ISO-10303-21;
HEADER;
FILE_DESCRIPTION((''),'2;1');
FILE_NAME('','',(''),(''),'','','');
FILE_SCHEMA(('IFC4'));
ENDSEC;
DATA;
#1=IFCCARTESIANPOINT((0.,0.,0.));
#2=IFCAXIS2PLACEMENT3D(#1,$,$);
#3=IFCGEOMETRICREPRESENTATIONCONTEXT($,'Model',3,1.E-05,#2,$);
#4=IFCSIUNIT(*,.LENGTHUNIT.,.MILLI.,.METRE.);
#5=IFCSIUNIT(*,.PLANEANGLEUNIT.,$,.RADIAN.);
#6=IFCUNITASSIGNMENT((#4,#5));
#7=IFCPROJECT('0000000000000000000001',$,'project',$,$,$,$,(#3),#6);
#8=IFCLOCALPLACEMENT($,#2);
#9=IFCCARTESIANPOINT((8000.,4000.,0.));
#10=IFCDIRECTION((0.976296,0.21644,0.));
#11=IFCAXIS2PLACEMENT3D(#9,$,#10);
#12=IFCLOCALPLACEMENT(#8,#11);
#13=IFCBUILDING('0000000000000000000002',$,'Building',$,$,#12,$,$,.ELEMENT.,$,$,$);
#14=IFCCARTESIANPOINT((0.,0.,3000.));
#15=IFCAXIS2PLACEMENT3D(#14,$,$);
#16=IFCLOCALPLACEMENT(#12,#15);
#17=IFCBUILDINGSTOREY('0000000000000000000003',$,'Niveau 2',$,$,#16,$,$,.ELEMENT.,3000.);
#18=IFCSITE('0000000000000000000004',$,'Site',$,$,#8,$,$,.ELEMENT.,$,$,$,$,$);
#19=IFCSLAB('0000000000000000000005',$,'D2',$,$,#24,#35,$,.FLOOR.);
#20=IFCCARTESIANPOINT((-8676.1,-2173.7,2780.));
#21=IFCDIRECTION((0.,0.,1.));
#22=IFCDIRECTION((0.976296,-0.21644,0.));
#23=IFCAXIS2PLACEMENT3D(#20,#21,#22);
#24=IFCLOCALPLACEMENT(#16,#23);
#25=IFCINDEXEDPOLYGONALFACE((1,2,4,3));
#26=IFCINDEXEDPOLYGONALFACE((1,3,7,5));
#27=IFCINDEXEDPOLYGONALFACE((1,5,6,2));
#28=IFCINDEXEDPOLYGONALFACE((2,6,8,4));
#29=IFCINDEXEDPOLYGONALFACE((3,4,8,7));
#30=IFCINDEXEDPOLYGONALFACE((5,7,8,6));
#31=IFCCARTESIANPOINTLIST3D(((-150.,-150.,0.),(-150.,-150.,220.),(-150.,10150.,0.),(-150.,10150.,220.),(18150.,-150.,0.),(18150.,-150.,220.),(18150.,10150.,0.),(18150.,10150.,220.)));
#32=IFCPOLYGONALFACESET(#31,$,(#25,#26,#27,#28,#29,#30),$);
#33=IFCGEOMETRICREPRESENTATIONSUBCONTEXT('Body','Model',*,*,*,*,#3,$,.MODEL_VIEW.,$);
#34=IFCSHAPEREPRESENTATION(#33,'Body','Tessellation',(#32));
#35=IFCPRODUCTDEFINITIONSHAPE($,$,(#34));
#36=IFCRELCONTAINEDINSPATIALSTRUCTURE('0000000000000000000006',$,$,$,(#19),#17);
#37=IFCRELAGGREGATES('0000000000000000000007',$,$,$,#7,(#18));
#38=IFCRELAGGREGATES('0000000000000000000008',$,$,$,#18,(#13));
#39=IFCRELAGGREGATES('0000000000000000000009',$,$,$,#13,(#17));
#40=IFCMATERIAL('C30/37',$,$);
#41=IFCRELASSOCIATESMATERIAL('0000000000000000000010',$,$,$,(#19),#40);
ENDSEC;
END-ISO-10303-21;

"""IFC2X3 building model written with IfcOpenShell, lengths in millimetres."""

from ifc_helpers import new_model, si_unit, frame, origin, place, context, subcontext, project, spatial, polyline, outline, extrude, material, element, save


model = new_model("IFC2X3")

# Units and contexts
model_context = context("Model", 3, precision=1e-05, world=origin())
body_context = subcontext(model_context, "Body", "Model", "MODEL_VIEW")
ifc_project = project(units=[si_unit("LENGTHUNIT", "METRE", prefix="MILLI"), si_unit("PLANEANGLEUNIT", "RADIAN")], contexts=[model_context])

# Site, building, storey
site_placement = place(None, origin())
site = spatial("IfcSite", under=ifc_project, at=site_placement, Name="Site", CompositionType="ELEMENT")
building_placement = place(site_placement, frame((8000.0, 4000.0, 0.0), x_axis=(0.976296, 0.21644, 0.0)))
building = spatial("IfcBuilding", under=site, at=building_placement, Name="Building", CompositionType="ELEMENT")
storey_placement = place(building_placement, frame((0.0, 0.0, 3000.0)))
storey = spatial("IfcBuildingStorey", under=building, at=storey_placement, Name="Niveau 2", CompositionType="ELEMENT", Elevation=3000.0)

# Shared definitions
ifc_material = material(Name="C30/37")

# Slab
slab_placement = place(storey_placement, frame((-8676.1, -2173.7, 2780.0), z_axis=(0.0, 0.0, 1.0), x_axis=(0.976296, -0.21644, 0.0)))
element("IfcSlab", 1, at=slab_placement, inside=storey, material=ifc_material, Name="D2", PredefinedType="FLOOR", context=body_context, shape_type="SweptSolid", body=[
    extrude(outline(polyline([(-150.0, -150.0), (18150.0, -150.0), (18150.0, 10150.0), (-150.0, 10150.0), (-150.0, -150.0)])), origin(), (0.0, 0.0, 1.0), 220.0),
])

save(model, "model.ifc")
